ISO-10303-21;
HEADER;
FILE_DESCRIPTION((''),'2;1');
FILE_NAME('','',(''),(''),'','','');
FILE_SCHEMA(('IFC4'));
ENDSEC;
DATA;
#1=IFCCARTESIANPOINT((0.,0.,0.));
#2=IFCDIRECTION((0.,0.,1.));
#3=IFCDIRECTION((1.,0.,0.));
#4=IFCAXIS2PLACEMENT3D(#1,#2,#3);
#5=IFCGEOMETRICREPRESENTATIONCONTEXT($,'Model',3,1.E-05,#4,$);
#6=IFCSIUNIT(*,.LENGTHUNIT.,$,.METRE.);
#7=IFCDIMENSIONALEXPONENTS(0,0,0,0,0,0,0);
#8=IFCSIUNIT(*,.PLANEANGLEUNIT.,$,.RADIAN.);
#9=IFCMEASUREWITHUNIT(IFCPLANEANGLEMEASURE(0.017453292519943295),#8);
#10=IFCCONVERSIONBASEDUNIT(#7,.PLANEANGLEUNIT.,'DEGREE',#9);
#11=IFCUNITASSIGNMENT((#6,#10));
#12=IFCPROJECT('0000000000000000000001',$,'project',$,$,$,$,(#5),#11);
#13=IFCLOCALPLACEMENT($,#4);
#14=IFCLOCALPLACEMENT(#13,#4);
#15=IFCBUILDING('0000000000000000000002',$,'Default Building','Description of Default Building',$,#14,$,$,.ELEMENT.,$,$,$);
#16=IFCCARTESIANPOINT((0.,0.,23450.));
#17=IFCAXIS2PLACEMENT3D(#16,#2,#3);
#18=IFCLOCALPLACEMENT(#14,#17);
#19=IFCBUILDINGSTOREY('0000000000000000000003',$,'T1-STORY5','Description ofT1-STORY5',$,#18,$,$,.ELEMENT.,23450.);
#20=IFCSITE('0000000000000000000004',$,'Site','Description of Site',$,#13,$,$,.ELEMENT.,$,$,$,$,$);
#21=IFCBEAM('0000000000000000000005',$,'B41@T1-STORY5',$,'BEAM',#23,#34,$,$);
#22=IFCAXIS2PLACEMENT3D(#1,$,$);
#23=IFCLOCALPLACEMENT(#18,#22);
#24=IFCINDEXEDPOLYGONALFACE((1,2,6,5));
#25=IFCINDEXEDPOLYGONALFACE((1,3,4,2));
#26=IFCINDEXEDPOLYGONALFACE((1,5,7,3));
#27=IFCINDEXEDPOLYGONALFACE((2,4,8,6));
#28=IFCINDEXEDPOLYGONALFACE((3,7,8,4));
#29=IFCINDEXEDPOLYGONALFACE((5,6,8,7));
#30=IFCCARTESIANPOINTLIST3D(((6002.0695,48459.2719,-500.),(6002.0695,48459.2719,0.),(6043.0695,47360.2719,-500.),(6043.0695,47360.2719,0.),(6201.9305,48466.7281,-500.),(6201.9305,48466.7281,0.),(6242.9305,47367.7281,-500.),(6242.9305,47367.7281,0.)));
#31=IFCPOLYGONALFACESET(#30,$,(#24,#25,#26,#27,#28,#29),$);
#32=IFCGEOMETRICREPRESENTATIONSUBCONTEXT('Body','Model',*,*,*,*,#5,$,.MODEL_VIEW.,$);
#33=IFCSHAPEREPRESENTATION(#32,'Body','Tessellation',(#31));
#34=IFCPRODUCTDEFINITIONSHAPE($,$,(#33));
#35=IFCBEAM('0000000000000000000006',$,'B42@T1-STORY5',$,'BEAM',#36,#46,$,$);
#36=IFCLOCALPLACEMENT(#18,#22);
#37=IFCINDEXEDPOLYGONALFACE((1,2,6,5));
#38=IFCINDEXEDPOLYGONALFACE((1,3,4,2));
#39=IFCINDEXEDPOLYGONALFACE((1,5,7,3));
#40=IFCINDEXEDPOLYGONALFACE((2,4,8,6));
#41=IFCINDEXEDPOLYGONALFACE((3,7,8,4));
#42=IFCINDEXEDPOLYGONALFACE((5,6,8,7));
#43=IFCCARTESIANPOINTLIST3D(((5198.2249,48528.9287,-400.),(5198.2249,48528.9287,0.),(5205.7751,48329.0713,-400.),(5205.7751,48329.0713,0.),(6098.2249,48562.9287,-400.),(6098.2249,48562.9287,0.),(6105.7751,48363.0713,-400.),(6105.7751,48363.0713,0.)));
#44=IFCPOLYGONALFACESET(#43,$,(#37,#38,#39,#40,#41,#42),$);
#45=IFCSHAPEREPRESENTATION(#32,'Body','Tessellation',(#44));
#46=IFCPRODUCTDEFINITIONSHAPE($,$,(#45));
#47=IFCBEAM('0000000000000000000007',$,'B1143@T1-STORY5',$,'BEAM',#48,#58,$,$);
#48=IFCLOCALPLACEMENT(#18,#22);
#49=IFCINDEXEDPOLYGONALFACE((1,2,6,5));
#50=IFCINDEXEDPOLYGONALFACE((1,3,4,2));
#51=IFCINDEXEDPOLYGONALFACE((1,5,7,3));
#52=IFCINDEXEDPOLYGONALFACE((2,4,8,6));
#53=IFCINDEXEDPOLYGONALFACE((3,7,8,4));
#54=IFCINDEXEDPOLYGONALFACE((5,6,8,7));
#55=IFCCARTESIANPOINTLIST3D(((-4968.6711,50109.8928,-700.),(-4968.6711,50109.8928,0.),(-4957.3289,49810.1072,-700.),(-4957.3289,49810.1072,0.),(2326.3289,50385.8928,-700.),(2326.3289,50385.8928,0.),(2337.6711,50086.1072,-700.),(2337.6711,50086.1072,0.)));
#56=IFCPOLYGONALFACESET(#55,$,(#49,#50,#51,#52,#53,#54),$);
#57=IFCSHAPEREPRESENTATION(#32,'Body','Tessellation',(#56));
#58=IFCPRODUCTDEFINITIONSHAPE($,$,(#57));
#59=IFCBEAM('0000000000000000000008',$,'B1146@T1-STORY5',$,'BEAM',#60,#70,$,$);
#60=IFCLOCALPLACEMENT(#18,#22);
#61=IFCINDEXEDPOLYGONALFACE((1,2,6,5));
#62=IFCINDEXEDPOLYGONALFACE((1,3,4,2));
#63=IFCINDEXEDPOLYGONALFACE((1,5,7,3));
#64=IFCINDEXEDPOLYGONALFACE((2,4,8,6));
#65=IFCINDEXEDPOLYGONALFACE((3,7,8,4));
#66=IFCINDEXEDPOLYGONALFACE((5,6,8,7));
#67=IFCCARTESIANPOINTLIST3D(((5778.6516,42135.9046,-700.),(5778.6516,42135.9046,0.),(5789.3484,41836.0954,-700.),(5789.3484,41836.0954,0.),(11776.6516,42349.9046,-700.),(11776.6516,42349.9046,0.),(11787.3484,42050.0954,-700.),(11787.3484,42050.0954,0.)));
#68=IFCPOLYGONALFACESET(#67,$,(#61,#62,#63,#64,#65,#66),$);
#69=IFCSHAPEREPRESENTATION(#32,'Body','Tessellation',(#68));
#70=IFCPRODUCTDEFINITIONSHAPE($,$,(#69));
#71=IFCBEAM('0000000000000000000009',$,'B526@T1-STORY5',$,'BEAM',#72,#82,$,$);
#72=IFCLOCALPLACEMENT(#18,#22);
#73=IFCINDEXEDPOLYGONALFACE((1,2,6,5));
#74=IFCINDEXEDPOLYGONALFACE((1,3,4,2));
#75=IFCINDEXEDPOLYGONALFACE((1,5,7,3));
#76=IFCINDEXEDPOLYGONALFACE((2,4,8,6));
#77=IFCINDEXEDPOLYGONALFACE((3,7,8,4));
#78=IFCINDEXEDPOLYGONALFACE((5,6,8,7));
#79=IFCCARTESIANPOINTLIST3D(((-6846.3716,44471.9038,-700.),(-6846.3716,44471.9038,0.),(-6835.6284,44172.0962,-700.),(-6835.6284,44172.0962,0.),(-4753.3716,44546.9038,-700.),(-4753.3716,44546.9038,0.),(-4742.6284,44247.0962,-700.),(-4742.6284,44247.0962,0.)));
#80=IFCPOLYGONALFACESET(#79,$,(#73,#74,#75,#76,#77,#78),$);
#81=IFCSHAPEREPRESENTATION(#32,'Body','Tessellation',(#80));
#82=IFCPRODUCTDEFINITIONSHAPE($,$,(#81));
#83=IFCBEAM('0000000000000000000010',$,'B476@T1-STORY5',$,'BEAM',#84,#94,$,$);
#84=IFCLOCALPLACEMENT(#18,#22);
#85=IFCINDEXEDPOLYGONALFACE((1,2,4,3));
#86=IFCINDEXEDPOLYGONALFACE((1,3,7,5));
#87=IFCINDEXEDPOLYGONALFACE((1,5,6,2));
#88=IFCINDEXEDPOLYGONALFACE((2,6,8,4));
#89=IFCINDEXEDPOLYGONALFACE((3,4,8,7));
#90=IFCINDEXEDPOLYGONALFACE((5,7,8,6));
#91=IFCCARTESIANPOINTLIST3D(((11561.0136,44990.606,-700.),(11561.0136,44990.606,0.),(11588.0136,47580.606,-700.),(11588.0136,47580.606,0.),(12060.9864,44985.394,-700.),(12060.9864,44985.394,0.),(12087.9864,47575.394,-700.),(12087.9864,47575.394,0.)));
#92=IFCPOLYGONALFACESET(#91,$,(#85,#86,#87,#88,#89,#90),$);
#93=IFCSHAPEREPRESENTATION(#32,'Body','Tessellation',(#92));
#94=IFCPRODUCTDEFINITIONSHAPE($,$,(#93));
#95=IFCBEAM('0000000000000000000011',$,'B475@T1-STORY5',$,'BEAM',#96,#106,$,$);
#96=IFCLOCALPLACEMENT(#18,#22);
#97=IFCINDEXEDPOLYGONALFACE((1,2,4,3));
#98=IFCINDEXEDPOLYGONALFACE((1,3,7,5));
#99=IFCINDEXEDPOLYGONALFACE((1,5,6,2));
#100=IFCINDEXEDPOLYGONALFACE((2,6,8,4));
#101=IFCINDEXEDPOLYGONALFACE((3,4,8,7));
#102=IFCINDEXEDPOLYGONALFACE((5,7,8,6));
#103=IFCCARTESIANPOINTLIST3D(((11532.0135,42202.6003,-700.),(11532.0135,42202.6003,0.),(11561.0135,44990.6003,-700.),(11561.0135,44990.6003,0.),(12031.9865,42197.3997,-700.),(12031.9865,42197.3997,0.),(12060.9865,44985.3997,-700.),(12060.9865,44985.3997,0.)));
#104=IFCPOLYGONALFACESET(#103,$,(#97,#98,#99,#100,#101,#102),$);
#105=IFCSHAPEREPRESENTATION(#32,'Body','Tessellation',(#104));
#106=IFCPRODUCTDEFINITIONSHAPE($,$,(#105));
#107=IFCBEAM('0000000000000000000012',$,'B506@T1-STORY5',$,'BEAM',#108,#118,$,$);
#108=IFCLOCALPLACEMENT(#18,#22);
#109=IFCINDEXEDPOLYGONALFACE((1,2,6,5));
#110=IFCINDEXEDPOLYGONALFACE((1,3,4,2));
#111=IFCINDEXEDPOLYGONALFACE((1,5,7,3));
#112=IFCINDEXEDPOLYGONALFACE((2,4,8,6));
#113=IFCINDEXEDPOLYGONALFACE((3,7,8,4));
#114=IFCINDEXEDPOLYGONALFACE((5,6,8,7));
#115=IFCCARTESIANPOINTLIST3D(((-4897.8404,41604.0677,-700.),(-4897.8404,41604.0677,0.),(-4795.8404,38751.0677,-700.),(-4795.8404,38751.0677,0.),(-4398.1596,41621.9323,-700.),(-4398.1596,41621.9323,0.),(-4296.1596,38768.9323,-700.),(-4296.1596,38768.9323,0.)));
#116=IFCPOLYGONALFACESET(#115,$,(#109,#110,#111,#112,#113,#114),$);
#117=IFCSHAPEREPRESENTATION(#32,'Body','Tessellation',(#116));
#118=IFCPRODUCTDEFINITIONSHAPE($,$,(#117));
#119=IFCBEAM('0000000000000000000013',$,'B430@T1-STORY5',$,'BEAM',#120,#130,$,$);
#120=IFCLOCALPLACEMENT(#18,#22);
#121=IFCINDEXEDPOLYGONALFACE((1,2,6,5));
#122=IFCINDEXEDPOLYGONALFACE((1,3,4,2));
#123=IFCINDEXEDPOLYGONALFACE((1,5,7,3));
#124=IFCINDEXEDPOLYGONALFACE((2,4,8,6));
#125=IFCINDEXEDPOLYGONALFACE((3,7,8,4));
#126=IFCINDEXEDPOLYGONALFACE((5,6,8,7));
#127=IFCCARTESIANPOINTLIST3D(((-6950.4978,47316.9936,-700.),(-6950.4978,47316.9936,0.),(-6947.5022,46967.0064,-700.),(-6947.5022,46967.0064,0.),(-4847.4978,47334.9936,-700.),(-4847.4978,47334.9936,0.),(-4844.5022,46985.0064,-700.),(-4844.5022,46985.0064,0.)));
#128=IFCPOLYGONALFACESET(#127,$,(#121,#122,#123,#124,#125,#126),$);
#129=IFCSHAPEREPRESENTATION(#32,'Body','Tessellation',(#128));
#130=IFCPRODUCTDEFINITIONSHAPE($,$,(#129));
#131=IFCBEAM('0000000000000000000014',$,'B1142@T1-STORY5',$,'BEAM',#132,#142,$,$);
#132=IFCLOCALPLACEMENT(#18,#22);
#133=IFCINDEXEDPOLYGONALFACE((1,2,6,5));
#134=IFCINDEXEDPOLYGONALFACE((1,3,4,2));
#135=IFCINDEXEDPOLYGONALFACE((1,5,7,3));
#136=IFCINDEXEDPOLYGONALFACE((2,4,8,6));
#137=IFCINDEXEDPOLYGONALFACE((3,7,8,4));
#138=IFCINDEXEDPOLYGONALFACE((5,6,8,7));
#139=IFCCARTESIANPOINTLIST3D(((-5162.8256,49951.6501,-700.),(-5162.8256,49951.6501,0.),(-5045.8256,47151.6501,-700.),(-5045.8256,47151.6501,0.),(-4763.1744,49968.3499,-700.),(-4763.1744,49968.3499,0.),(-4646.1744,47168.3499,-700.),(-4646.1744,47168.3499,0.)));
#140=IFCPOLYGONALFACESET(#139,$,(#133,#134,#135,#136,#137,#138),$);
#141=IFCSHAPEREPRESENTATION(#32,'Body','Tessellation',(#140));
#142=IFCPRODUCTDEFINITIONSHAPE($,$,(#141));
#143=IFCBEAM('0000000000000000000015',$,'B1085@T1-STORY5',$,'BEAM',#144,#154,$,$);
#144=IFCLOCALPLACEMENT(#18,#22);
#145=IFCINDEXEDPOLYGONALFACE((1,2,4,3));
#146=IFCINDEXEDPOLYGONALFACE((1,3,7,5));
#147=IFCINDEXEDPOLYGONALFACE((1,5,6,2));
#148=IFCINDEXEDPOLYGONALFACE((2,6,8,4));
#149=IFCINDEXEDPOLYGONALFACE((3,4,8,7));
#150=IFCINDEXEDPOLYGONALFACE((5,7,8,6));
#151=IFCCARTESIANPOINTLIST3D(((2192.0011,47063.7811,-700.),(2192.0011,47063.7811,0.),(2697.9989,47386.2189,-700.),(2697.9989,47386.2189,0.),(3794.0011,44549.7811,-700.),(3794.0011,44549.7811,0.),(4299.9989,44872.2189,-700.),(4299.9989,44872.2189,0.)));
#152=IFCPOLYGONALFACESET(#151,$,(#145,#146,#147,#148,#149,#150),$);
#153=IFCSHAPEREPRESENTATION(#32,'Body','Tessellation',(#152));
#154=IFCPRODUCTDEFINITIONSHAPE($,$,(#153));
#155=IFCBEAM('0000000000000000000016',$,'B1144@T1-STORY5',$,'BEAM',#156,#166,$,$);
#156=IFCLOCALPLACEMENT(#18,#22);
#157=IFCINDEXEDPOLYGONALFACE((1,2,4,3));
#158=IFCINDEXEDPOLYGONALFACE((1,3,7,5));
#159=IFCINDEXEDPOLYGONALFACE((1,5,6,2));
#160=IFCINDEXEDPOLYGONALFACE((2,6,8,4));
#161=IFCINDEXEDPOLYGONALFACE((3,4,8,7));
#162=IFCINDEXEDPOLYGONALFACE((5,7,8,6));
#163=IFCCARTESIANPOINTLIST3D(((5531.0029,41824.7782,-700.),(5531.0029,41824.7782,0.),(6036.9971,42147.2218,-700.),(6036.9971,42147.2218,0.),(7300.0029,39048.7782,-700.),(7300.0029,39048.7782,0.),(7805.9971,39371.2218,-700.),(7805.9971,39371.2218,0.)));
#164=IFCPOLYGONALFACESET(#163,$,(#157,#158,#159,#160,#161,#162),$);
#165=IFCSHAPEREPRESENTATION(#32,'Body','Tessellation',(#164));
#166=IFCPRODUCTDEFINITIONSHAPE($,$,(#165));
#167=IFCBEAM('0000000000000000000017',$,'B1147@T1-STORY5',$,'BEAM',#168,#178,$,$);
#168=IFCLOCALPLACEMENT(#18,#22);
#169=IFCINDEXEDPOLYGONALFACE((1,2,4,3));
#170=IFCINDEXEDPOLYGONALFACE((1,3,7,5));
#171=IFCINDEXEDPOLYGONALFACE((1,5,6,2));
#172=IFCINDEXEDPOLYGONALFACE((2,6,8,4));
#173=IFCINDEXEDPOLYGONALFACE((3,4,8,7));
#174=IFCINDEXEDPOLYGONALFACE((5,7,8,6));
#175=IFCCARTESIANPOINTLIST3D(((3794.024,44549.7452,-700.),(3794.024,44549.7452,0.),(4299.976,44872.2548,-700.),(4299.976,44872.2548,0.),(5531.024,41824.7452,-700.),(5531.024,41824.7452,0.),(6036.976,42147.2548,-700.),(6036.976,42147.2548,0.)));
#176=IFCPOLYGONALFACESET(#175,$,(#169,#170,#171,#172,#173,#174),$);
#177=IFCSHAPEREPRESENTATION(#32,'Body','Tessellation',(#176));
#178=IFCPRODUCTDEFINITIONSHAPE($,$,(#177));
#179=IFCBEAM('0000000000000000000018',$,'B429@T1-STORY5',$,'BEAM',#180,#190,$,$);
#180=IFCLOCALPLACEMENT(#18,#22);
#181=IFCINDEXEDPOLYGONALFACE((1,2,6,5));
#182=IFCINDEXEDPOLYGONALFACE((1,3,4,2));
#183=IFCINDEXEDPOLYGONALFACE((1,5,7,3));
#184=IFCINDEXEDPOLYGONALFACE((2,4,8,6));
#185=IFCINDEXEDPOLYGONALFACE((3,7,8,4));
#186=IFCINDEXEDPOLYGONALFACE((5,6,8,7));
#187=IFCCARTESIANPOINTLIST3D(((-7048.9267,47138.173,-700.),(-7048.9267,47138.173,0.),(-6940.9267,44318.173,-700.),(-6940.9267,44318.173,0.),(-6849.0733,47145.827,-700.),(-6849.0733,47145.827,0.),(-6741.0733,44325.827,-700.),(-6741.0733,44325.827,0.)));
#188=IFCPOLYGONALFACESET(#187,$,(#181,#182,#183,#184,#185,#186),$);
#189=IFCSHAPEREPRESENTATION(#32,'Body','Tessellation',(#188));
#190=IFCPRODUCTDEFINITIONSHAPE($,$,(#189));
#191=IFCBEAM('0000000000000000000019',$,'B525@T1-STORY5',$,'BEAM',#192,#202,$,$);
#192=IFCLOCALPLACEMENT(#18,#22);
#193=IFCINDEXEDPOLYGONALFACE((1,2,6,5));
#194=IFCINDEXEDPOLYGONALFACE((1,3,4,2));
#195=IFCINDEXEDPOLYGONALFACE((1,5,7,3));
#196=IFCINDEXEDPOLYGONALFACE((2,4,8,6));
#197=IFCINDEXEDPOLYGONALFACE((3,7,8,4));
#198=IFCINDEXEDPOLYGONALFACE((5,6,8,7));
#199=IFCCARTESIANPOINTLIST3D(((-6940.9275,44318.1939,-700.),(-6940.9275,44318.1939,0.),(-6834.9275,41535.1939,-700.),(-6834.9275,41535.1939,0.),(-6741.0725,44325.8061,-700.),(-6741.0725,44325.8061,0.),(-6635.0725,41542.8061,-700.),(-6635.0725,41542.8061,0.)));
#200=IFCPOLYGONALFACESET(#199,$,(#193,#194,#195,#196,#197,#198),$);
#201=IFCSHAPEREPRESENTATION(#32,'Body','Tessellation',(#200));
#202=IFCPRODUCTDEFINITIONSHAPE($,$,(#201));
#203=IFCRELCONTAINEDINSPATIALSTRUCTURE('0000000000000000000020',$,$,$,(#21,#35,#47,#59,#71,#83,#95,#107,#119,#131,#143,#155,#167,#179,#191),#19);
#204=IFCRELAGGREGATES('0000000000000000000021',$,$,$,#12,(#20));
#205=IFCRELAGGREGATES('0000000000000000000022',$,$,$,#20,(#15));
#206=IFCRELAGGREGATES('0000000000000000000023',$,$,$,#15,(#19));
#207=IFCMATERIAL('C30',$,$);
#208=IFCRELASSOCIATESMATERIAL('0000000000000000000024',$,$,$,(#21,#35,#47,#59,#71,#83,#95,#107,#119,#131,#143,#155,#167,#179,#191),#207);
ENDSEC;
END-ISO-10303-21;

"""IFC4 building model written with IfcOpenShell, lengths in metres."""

from ifc_helpers import new_model, entity, si_unit, converted_unit, frame, origin_with_axes, place, context, subcontext, project, spatial, rectangle, extrude, material, element, save


model = new_model("IFC4")

# Units and contexts
model_context = context("Model", 3, precision=1e-05, world=origin_with_axes())
body_context = subcontext(model_context, "Body", "Model", "MODEL_VIEW")
ifc_project = project(units=[si_unit("LENGTHUNIT", "METRE"), converted_unit("PLANEANGLEUNIT", "DEGREE", entity("IfcPlaneAngleMeasure", 0.017453292519943295), si_unit("PLANEANGLEUNIT", "RADIAN"), dimensions=[0, 0, 0, 0, 0, 0, 0])], contexts=[model_context])

# Site, building, storey
site_placement = place(None, origin_with_axes())
site = spatial("IfcSite", under=ifc_project, at=site_placement, Name="Site", Description="Description of Site", CompositionType="ELEMENT")
building_placement = place(site_placement, origin_with_axes())
building = spatial("IfcBuilding", under=site, at=building_placement, Name="Default Building", Description="Description of Default Building", CompositionType="ELEMENT")
storey_placement = place(building_placement, frame((0.0, 0.0, 23450.0), z_axis=(0.0, 0.0, 1.0), x_axis=(1.0, 0.0, 0.0)))
storey = spatial("IfcBuildingStorey", under=building, at=storey_placement, Name="T1-STORY5", Description="Description ofT1-STORY5", CompositionType="ELEMENT", Elevation=23450.0)

# Beams
ifc_material_1 = material(Name="C30")
beam_1_placement = place(storey_placement, frame((6102.0, 48463.0, -250.0), z_axis=(0.037281, -0.999305, 0.0), x_axis=(0.999305, 0.037281, 0.0)))
element("IfcBeam", 1, at=beam_1_placement, inside=storey, material=ifc_material_1, Name="B41@T1-STORY5", ObjectType="BEAM", context=body_context, shape_type="SweptSolid", body=[
    extrude(rectangle(XDim=200.0, YDim=500.0), origin_with_axes(), (0.0, 0.0, 1.0), 1099.7645),
])
beam_2_placement = place(storey_placement, frame((5202.0, 48429.0, -200.0), z_axis=(0.999287, 0.037751, 0.0), x_axis=(-0.037751, 0.999287, 0.0)))
element("IfcBeam", 2, at=beam_2_placement, inside=storey, material=ifc_material_1, Name="B42@T1-STORY5", ObjectType="BEAM", context=body_context, shape_type="SweptSolid", body=[
    extrude(rectangle(XDim=200.0, YDim=400.0), origin_with_axes(), (0.0, 0.0, 1.0), 900.642),
])
beam_3_placement = place(storey_placement, frame((-4963.0, 49960.0, -350.0), z_axis=(0.999285, 0.037807, 0.0), x_axis=(-0.037807, 0.999285, 0.0)))
element("IfcBeam", 3, at=beam_3_placement, inside=storey, material=ifc_material_1, Name="B1143@T1-STORY5", ObjectType="BEAM", context=body_context, shape_type="SweptSolid", body=[
    extrude(rectangle(XDim=300.0, YDim=700.0), origin_with_axes(), (0.0, 0.0, 1.0), 7300.2192),
])
beam_4_placement = place(storey_placement, frame((5784.0, 41986.0, -350.0), z_axis=(0.999364, 0.035656, 0.0), x_axis=(-0.035656, 0.999364, 0.0)))
element("IfcBeam", 4, at=beam_4_placement, inside=storey, material=ifc_material_1, Name="B1146@T1-STORY5", ObjectType="BEAM", context=body_context, shape_type="SweptSolid", body=[
    extrude(rectangle(XDim=300.0, YDim=700.0), origin_with_axes(), (0.0, 0.0, 1.0), 6001.8164),
])
beam_5_placement = place(storey_placement, frame((-6841.0, 44322.0, -350.0), z_axis=(0.999359, 0.035811, 0.0), x_axis=(-0.035811, 0.999359, 0.0)))
element("IfcBeam", 5, at=beam_5_placement, inside=storey, material=ifc_material_1, Name="B526@T1-STORY5", ObjectType="BEAM", context=body_context, shape_type="SweptSolid", body=[
    extrude(rectangle(XDim=300.0, YDim=700.0), origin_with_axes(), (0.0, 0.0, 1.0), 2094.3433),
])
beam_6_placement = place(storey_placement, frame((11811.0, 44988.0, -350.0), z_axis=(0.010424, 0.999946, 0.0), x_axis=(-0.999946, 0.010424, 0.0)))
element("IfcBeam", 6, at=beam_6_placement, inside=storey, material=ifc_material_1, Name="B476@T1-STORY5", ObjectType="BEAM", context=body_context, shape_type="SweptSolid", body=[
    extrude(rectangle(XDim=500.0, YDim=700.0), origin_with_axes(), (0.0, 0.0, 1.0), 2590.1407),
])
beam_7_placement = place(storey_placement, frame((11782.0, 42200.0, -350.0), z_axis=(0.010401, 0.999946, 0.0), x_axis=(-0.999946, 0.010401, 0.0)))
element("IfcBeam", 7, at=beam_7_placement, inside=storey, material=ifc_material_1, Name="B475@T1-STORY5", ObjectType="BEAM", context=body_context, shape_type="SweptSolid", body=[
    extrude(rectangle(XDim=500.0, YDim=700.0), origin_with_axes(), (0.0, 0.0, 1.0), 2788.1508),
])
beam_8_placement = place(storey_placement, frame((-4648.0, 41613.0, -350.0), z_axis=(0.035729, -0.999362, 0.0), x_axis=(0.999362, 0.035729, 0.0)))
element("IfcBeam", 8, at=beam_8_placement, inside=storey, material=ifc_material_1, Name="B506@T1-STORY5", ObjectType="BEAM", context=body_context, shape_type="SweptSolid", body=[
    extrude(rectangle(XDim=500.0, YDim=700.0), origin_with_axes(), (0.0, 0.0, 1.0), 2854.8228),
])
beam_9_placement = place(storey_placement, frame((-6949.0, 47142.0, -350.0), z_axis=(0.999963, 0.008559, 0.0), x_axis=(-0.008559, 0.999963, 0.0)))
element("IfcBeam", 9, at=beam_9_placement, inside=storey, material=ifc_material_1, Name="B430@T1-STORY5", ObjectType="BEAM", context=body_context, shape_type="SweptSolid", body=[
    extrude(rectangle(XDim=350.0, YDim=700.0), origin_with_axes(), (0.0, 0.0, 1.0), 2103.077),
])
beam_10_placement = place(storey_placement, frame((-4963.0, 49960.0, -350.0), z_axis=(0.041749, -0.999128, 0.0), x_axis=(0.999128, 0.041749, 0.0)))
element("IfcBeam", 10, at=beam_10_placement, inside=storey, material=ifc_material_1, Name="B1142@T1-STORY5", ObjectType="BEAM", context=body_context, shape_type="SweptSolid", body=[
    extrude(rectangle(XDim=400.0, YDim=700.0), origin_with_axes(), (0.0, 0.0, 1.0), 2802.4434),
])
beam_11_placement = place(storey_placement, frame((2445.0, 47225.0, -350.0), z_axis=(0.537396, -0.84333, 0.0), x_axis=(0.84333, 0.537396, 0.0)))
element("IfcBeam", 11, at=beam_11_placement, inside=storey, material=ifc_material_1, Name="B1085@T1-STORY5", ObjectType="BEAM", context=body_context, shape_type="SweptSolid", body=[
    extrude(rectangle(XDim=600.0, YDim=700.0), origin_with_axes(), (0.0, 0.0, 1.0), 2981.0401),
])
beam_12_placement = place(storey_placement, frame((5784.0, 41986.0, -350.0), z_axis=(0.537406, -0.843324, 0.0), x_axis=(0.843324, 0.537406, 0.0)))
element("IfcBeam", 12, at=beam_12_placement, inside=storey, material=ifc_material_1, Name="B1144@T1-STORY5", ObjectType="BEAM", context=body_context, shape_type="SweptSolid", body=[
    extrude(rectangle(XDim=600.0, YDim=700.0), origin_with_axes(), (0.0, 0.0, 1.0), 3291.7377),
])
beam_13_placement = place(storey_placement, frame((4047.0, 44711.0, -350.0), z_axis=(0.537516, -0.843253, 0.0), x_axis=(0.843253, 0.537516, 0.0)))
element("IfcBeam", 13, at=beam_13_placement, inside=storey, material=ifc_material_1, Name="B1147@T1-STORY5", ObjectType="BEAM", context=body_context, shape_type="SweptSolid", body=[
    extrude(rectangle(XDim=600.0, YDim=700.0), origin_with_axes(), (0.0, 0.0, 1.0), 3231.5312),
])
beam_14_placement = place(storey_placement, frame((-6949.0, 47142.0, -350.0), z_axis=(0.03827, -0.999267, 0.0), x_axis=(0.999267, 0.03827, 0.0)))
element("IfcBeam", 14, at=beam_14_placement, inside=storey, material=ifc_material_1, Name="B429@T1-STORY5", ObjectType="BEAM", context=body_context, shape_type="SweptSolid", body=[
    extrude(rectangle(XDim=200.0, YDim=700.0), origin_with_axes(), (0.0, 0.0, 1.0), 2822.0673),
])
beam_15_placement = place(storey_placement, frame((-6841.0, 44322.0, -350.0), z_axis=(0.038061, -0.999275, 0.0), x_axis=(0.999275, 0.038061, 0.0)))
element("IfcBeam", 15, at=beam_15_placement, inside=storey, material=ifc_material_1, Name="B525@T1-STORY5", ObjectType="BEAM", context=body_context, shape_type="SweptSolid", body=[
    extrude(rectangle(XDim=200.0, YDim=700.0), origin_with_axes(), (0.0, 0.0, 1.0), 2785.018),
])

save(model, "model.ifc")
